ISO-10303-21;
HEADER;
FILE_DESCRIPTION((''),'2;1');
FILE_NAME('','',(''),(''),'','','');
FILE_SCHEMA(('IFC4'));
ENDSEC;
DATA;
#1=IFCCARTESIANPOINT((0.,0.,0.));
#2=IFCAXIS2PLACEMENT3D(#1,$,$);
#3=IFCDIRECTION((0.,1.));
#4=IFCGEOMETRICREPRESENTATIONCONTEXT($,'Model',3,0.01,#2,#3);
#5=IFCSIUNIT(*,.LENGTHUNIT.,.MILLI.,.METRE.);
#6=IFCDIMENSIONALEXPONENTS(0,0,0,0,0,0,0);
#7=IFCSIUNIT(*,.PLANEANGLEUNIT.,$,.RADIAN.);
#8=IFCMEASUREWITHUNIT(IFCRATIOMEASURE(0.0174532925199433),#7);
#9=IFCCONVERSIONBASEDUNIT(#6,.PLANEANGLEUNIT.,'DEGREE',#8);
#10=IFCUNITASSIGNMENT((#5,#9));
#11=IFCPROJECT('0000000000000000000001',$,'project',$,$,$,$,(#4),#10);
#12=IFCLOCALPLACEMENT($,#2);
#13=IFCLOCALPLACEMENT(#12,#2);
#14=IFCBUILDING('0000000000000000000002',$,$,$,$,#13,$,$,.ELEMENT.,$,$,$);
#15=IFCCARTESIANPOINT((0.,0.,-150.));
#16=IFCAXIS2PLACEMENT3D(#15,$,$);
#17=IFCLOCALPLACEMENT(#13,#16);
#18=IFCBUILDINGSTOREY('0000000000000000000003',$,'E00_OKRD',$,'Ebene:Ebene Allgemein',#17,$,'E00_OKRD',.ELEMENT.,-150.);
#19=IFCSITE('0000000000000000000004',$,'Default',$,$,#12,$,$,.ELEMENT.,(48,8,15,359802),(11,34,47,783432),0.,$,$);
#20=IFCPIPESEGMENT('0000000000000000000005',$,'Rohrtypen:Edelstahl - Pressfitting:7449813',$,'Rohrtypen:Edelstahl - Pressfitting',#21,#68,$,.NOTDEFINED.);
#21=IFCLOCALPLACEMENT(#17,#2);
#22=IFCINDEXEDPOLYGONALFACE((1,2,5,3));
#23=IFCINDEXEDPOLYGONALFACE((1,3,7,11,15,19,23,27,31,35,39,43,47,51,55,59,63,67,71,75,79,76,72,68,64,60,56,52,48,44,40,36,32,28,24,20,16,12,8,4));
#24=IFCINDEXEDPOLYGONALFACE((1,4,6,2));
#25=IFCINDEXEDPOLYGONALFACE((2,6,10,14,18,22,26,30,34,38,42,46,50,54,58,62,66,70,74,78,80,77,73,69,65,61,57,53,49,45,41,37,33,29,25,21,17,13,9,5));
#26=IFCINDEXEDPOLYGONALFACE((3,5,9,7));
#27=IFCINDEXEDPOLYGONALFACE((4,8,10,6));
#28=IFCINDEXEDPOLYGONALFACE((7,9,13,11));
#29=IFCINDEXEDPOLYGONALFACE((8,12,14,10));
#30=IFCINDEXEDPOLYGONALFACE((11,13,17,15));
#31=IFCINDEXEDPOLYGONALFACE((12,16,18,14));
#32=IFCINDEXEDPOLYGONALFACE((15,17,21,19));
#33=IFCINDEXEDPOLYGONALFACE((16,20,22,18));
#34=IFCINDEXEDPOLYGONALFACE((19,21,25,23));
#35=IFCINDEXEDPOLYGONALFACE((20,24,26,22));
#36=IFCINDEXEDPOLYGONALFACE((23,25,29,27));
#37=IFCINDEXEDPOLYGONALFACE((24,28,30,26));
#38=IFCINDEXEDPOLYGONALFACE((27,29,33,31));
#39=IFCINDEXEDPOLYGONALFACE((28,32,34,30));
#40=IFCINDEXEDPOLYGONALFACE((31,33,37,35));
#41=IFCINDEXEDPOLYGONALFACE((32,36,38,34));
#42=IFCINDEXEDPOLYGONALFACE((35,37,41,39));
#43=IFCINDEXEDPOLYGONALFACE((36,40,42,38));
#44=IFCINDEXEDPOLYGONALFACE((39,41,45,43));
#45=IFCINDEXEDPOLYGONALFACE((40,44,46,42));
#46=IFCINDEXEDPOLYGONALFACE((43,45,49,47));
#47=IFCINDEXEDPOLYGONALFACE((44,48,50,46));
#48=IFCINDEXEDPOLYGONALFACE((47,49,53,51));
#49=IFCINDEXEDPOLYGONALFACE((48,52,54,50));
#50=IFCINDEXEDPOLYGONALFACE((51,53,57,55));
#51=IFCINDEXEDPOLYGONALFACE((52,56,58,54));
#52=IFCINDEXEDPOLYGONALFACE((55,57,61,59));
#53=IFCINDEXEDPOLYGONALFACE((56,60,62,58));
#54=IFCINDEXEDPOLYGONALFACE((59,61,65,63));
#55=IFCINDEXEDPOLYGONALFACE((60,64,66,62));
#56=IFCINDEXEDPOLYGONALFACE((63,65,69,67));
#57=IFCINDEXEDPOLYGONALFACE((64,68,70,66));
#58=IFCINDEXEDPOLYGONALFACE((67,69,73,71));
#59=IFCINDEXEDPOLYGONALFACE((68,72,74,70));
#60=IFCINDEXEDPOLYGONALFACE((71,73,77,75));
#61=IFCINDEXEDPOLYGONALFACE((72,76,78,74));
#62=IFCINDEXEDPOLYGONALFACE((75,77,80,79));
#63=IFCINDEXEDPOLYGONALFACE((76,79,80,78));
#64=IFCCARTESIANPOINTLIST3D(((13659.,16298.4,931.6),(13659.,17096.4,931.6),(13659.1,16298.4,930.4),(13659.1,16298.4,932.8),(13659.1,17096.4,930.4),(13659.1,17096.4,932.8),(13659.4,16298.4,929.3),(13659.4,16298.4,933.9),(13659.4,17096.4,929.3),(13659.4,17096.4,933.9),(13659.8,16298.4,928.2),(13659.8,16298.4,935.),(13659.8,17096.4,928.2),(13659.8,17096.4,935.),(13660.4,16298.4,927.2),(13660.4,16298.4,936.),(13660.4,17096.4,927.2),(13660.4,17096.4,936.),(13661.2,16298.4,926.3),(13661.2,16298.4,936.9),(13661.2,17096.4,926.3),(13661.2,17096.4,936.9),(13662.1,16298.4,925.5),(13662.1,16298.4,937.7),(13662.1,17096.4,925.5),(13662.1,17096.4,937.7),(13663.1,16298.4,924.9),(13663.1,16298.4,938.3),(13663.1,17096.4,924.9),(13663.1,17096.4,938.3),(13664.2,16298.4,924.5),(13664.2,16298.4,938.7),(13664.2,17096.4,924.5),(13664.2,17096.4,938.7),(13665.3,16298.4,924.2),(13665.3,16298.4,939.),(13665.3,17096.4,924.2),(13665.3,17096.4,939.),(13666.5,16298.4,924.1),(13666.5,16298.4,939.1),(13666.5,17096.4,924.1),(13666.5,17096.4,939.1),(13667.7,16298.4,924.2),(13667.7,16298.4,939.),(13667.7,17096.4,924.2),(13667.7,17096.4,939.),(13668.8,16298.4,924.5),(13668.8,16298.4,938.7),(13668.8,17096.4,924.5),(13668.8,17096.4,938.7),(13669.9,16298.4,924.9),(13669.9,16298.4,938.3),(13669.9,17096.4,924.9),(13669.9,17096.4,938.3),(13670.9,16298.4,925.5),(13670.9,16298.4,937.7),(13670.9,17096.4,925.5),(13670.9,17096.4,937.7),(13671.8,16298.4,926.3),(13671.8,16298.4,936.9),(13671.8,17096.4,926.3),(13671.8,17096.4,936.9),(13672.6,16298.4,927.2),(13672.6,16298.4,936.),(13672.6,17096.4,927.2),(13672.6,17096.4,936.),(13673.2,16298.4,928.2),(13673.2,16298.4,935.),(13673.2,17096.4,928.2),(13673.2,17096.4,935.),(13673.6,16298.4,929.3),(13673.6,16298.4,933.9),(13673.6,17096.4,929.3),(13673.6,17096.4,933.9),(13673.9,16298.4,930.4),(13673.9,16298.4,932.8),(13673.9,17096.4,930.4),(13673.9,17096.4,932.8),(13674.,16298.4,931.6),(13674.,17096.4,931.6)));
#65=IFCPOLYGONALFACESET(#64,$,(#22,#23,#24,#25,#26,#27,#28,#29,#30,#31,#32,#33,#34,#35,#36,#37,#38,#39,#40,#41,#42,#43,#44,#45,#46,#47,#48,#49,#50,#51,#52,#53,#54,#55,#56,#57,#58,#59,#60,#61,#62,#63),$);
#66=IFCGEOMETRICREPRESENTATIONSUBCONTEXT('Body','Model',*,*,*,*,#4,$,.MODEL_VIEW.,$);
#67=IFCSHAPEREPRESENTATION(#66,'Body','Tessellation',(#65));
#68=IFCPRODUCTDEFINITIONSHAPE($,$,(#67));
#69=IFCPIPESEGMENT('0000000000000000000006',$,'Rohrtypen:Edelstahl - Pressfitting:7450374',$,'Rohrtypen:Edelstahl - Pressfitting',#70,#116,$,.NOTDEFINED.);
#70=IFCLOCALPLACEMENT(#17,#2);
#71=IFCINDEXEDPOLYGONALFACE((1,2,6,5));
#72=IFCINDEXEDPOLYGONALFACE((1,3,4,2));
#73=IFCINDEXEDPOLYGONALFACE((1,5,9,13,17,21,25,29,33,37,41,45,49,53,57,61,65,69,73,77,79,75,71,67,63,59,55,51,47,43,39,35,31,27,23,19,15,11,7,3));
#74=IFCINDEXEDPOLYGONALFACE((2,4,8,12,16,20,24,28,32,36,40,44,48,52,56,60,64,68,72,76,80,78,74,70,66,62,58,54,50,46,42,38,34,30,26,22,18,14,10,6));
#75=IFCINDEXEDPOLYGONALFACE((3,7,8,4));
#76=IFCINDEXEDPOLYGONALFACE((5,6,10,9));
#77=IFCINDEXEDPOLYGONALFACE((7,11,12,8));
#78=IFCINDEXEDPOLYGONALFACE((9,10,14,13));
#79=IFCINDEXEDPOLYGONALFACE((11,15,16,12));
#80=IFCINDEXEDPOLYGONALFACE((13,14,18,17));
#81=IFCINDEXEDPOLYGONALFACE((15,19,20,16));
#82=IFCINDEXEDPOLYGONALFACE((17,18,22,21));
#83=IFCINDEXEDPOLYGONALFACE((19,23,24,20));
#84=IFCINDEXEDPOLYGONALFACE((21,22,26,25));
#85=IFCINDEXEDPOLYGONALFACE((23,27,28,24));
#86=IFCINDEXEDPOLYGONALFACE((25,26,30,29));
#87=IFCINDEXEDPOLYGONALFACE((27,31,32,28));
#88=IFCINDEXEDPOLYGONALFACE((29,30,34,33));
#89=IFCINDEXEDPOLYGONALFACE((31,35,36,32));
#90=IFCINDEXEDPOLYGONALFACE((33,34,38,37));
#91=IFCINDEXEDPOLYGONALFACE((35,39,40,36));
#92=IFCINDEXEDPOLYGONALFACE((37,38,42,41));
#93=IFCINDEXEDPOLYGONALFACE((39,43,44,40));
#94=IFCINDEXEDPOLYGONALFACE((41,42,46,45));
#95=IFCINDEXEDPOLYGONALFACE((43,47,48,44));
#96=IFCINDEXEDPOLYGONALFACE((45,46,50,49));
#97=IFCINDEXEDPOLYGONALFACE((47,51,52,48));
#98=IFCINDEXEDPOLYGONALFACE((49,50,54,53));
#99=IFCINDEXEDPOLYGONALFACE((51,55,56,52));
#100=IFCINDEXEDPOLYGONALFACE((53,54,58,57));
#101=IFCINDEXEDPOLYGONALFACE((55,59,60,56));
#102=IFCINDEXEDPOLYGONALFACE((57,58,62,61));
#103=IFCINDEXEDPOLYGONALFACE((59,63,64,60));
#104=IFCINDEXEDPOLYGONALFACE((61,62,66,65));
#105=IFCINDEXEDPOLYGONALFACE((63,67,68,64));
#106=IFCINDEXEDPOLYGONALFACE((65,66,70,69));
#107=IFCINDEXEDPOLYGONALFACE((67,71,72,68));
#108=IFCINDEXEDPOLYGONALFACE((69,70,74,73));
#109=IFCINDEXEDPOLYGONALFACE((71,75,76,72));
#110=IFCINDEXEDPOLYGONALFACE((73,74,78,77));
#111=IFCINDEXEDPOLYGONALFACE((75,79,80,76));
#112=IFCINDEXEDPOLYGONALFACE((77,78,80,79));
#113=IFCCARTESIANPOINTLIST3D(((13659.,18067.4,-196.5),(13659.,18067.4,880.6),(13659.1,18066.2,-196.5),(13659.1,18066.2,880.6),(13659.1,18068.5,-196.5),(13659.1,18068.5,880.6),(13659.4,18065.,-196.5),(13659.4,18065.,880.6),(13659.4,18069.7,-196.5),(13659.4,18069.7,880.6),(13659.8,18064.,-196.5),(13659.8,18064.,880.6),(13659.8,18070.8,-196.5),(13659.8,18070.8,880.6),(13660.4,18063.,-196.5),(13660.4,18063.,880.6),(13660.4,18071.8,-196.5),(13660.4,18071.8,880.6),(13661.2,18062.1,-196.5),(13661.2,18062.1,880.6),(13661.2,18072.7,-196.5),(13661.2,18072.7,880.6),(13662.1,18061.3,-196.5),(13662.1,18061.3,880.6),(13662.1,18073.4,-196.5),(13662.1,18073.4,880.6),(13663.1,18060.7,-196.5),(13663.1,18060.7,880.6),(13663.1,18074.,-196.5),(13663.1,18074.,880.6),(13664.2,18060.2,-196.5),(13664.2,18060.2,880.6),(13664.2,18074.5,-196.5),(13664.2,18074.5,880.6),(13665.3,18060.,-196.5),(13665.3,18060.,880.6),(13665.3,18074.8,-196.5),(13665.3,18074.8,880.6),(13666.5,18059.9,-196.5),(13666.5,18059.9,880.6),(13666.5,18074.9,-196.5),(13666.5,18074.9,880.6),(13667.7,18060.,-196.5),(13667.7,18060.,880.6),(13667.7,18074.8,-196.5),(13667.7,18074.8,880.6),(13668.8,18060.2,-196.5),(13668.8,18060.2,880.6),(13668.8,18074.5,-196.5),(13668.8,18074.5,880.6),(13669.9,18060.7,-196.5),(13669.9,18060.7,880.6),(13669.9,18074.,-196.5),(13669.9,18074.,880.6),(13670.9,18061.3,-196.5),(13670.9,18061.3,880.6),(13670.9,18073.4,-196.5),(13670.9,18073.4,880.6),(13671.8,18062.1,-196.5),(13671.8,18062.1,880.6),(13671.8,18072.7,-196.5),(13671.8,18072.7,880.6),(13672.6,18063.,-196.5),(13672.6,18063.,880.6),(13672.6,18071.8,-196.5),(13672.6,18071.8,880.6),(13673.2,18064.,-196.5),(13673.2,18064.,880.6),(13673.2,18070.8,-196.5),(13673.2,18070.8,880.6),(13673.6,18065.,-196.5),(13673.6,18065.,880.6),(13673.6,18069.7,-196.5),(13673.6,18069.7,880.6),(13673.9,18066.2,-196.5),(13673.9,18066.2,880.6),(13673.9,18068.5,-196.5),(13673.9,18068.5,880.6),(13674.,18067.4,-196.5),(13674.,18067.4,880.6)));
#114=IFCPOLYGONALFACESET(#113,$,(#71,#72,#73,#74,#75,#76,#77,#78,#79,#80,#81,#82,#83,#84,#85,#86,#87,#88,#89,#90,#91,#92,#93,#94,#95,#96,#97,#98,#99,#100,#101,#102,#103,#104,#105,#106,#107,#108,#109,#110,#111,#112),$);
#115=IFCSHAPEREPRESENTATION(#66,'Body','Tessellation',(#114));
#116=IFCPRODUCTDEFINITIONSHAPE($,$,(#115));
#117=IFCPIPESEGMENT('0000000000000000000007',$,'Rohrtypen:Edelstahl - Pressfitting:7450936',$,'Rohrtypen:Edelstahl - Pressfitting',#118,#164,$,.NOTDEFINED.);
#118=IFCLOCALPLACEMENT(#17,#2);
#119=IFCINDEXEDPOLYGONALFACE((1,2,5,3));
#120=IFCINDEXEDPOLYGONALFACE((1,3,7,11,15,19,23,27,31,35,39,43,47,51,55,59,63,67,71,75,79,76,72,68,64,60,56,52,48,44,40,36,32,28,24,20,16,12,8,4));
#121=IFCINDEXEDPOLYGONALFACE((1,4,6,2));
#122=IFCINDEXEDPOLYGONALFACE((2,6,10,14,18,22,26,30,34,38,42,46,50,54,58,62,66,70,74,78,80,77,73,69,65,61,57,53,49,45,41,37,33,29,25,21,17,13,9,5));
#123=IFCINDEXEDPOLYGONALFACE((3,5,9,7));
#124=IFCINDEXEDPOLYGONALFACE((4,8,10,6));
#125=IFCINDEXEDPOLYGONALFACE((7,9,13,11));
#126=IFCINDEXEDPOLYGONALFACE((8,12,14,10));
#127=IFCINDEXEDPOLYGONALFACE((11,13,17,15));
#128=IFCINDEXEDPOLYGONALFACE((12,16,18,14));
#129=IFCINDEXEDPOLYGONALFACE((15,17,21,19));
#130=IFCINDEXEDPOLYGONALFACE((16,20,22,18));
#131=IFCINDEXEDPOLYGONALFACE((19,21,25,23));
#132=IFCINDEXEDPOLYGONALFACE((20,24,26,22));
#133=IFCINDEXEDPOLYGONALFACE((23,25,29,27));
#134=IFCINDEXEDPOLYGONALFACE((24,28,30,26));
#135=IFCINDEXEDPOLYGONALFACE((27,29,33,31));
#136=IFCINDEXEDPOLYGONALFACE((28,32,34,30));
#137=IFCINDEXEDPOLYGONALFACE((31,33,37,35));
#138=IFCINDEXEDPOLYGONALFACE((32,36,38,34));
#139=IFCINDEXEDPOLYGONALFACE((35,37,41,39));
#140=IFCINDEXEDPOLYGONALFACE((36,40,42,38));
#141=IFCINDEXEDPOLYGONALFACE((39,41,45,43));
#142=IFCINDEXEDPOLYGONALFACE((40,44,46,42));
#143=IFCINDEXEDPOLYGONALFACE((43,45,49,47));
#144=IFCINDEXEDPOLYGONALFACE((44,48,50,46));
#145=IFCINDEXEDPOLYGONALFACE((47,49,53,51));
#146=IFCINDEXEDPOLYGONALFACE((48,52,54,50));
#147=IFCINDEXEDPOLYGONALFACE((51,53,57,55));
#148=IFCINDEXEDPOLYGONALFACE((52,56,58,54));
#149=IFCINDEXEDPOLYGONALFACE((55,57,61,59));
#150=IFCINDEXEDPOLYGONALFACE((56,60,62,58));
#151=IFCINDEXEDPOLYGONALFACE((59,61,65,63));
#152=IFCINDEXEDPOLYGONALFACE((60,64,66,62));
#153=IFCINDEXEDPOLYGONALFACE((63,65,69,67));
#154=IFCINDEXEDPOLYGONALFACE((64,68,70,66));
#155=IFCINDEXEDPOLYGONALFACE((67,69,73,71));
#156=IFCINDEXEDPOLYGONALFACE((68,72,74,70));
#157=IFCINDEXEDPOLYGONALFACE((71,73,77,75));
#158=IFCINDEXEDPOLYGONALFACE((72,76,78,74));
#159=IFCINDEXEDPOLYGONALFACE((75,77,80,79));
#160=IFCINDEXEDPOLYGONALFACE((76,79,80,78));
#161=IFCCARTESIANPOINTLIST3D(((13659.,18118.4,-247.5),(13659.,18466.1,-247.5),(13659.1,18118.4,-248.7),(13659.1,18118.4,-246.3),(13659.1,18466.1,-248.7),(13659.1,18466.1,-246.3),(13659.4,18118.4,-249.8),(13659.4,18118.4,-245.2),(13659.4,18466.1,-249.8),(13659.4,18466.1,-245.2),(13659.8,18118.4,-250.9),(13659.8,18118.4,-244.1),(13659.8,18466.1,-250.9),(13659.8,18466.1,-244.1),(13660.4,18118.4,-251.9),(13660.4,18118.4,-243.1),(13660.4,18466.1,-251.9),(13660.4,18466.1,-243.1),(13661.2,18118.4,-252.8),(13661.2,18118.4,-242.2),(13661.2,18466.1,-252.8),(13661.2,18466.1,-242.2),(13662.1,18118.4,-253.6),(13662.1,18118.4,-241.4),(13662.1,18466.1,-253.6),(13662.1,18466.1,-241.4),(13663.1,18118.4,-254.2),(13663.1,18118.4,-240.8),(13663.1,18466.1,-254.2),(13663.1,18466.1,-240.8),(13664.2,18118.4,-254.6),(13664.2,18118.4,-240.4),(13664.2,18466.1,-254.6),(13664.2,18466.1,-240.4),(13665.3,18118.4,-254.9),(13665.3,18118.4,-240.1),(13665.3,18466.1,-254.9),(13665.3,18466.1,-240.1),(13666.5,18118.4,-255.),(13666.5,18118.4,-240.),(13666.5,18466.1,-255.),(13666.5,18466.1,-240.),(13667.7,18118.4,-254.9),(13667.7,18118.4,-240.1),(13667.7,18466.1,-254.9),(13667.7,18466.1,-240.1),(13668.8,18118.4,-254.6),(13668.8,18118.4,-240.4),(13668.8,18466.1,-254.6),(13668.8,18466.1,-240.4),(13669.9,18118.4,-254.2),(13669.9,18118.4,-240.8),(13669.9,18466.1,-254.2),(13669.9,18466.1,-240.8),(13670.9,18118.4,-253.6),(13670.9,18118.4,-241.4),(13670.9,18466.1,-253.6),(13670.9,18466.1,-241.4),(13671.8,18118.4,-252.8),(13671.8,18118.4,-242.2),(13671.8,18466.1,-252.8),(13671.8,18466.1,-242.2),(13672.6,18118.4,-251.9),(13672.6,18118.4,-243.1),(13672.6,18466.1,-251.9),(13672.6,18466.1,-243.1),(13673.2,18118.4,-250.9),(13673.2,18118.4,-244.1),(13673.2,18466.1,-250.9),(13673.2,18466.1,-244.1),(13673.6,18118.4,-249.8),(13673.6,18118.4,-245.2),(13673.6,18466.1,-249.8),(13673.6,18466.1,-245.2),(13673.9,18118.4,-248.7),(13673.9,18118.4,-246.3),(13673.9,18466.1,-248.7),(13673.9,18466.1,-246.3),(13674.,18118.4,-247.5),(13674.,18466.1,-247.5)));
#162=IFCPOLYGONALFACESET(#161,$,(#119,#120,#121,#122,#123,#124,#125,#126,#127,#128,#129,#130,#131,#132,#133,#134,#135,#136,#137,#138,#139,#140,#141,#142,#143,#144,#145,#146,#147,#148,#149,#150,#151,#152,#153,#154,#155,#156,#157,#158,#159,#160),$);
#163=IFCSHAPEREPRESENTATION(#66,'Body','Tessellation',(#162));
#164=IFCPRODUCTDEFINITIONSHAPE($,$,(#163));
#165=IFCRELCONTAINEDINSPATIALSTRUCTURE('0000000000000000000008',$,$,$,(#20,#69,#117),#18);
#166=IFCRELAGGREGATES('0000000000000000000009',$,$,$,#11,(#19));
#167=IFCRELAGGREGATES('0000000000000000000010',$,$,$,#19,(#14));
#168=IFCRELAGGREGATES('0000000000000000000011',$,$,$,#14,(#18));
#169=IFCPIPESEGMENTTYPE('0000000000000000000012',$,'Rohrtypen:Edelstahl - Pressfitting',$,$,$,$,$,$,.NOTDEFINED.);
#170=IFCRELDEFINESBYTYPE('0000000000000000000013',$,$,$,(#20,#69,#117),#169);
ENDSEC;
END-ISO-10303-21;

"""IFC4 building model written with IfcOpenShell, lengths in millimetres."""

from ifc_helpers import new_model, entity, si_unit, converted_unit, direction, frame, origin, place, context, subcontext, project, spatial, indexed_curve, outline, extrude, type_object, element, save


model = new_model("IFC4")

# Units and contexts
model_context = context("Model", 3, precision=0.01, world=origin(), true_north=direction((0.0, 1.0)))
body_context = subcontext(model_context, "Body", "Model", "MODEL_VIEW")
ifc_project = project(units=[si_unit("LENGTHUNIT", "METRE", prefix="MILLI"), converted_unit("PLANEANGLEUNIT", "DEGREE", entity("IfcRatioMeasure", 0.0174532925199433), si_unit("PLANEANGLEUNIT", "RADIAN"), dimensions=[0, 0, 0, 0, 0, 0, 0])], contexts=[model_context])

# Site, building, storey
site_placement = place(None, origin())
site = spatial("IfcSite", under=ifc_project, at=site_placement, Name="Default", CompositionType="ELEMENT", RefLatitude=(48, 8, 15, 359802), RefLongitude=(11, 34, 47, 783432), RefElevation=0.0)
building_placement = place(site_placement, origin())
building = spatial("IfcBuilding", under=site, at=building_placement, CompositionType="ELEMENT")
storey_placement = place(building_placement, frame((0.0, 0.0, -150.0)))
storey = spatial("IfcBuildingStorey", under=building, at=storey_placement, Name="E00_OKRD", ObjectType="Ebene:Ebene Allgemein", LongName="E00_OKRD", CompositionType="ELEMENT", Elevation=-150.0)

# Pipe segments
pipe_segment_type_1 = type_object("IfcPipeSegmentType", Name="Rohrtypen:Edelstahl - Pressfitting", PredefinedType="NOTDEFINED")
pipe_segment_1_placement = place(storey_placement, origin())
element("IfcPipeSegment", 1, at=pipe_segment_1_placement, inside=storey, type_object=pipe_segment_type_1, Name="Rohrtypen:Edelstahl - Pressfitting:7449813", ObjectType="Rohrtypen:Edelstahl - Pressfitting", PredefinedType="NOTDEFINED", context=body_context, shape_type="SweptSolid", body=[
    extrude(outline(indexed_curve([(7.5, 0.0), (7.4, 1.2), (7.1, 2.3), (6.7, 3.4), (6.1, 4.4), (5.3, 5.3), (4.4, 6.1), (3.4, 6.7), (2.3, 7.1), (1.2, 7.4), (0.0, 7.5), (-1.2, 7.4), (-2.3, 7.1), (-3.4, 6.7), (-4.4, 6.1), (-5.3, 5.3), (-6.1, 4.4), (-6.7, 3.4), (-7.1, 2.3), (-7.4, 1.2), (-7.5, 0.0), (-7.4, -1.2), (-7.1, -2.3), (-6.7, -3.4), (-6.1, -4.4), (-5.3, -5.3), (-4.4, -6.1), (-3.4, -6.7), (-2.3, -7.1), (-1.2, -7.4), (0.0, -7.5), (1.2, -7.4), (2.3, -7.1), (3.4, -6.7), (4.4, -6.1), (5.3, -5.3), (6.1, -4.4), (6.7, -3.4), (7.1, -2.3), (7.4, -1.2), (7.5, 0.0)], self_intersect=False)), frame((13666.5, 16298.4, 931.6), z_axis=(0.0, 1.0, 0.0), x_axis=(1.0, 0.0, 0.0)), (0.0, 0.0, 1.0), 798.0),
])
pipe_segment_2_placement = place(storey_placement, origin())
element("IfcPipeSegment", 2, at=pipe_segment_2_placement, inside=storey, type_object=pipe_segment_type_1, Name="Rohrtypen:Edelstahl - Pressfitting:7450374", ObjectType="Rohrtypen:Edelstahl - Pressfitting", PredefinedType="NOTDEFINED", context=body_context, shape_type="SweptSolid", body=[
    extrude(outline(indexed_curve([(7.5, 0.0), (7.4, 1.2), (7.1, 2.3), (6.7, 3.4), (6.1, 4.4), (5.3, 5.3), (4.4, 6.1), (3.4, 6.7), (2.3, 7.1), (1.2, 7.4), (0.0, 7.5), (-1.2, 7.4), (-2.3, 7.1), (-3.4, 6.7), (-4.4, 6.1), (-5.3, 5.3), (-6.1, 4.4), (-6.7, 3.4), (-7.1, 2.3), (-7.4, 1.2), (-7.5, 0.0), (-7.4, -1.2), (-7.1, -2.3), (-6.7, -3.4), (-6.1, -4.4), (-5.3, -5.3), (-4.4, -6.1), (-3.4, -6.7), (-2.3, -7.1), (-1.2, -7.4), (0.0, -7.5), (1.2, -7.4), (2.3, -7.1), (3.4, -6.7), (4.4, -6.1), (5.3, -5.3), (6.1, -4.4), (6.7, -3.4), (7.1, -2.3), (7.4, -1.2), (7.5, 0.0)], self_intersect=False)), frame((13666.5, 18067.4, -196.5)), (0.0, 0.0, 1.0), 1077.1),
])
pipe_segment_3_placement = place(storey_placement, origin())
element("IfcPipeSegment", 3, at=pipe_segment_3_placement, inside=storey, type_object=pipe_segment_type_1, Name="Rohrtypen:Edelstahl - Pressfitting:7450936", ObjectType="Rohrtypen:Edelstahl - Pressfitting", PredefinedType="NOTDEFINED", context=body_context, shape_type="SweptSolid", body=[
    extrude(outline(indexed_curve([(7.5, 0.0), (7.4, 1.2), (7.1, 2.3), (6.7, 3.4), (6.1, 4.4), (5.3, 5.3), (4.4, 6.1), (3.4, 6.7), (2.3, 7.1), (1.2, 7.4), (0.0, 7.5), (-1.2, 7.4), (-2.3, 7.1), (-3.4, 6.7), (-4.4, 6.1), (-5.3, 5.3), (-6.1, 4.4), (-6.7, 3.4), (-7.1, 2.3), (-7.4, 1.2), (-7.5, 0.0), (-7.4, -1.2), (-7.1, -2.3), (-6.7, -3.4), (-6.1, -4.4), (-5.3, -5.3), (-4.4, -6.1), (-3.4, -6.7), (-2.3, -7.1), (-1.2, -7.4), (0.0, -7.5), (1.2, -7.4), (2.3, -7.1), (3.4, -6.7), (4.4, -6.1), (5.3, -5.3), (6.1, -4.4), (6.7, -3.4), (7.1, -2.3), (7.4, -1.2), (7.5, 0.0)], self_intersect=False)), frame((13666.5, 18118.4, -247.5), z_axis=(0.0, 1.0, 0.0), x_axis=(1.0, 0.0, 0.0)), (0.0, 0.0, 1.0), 347.8),
])

save(model, "model.ifc")
